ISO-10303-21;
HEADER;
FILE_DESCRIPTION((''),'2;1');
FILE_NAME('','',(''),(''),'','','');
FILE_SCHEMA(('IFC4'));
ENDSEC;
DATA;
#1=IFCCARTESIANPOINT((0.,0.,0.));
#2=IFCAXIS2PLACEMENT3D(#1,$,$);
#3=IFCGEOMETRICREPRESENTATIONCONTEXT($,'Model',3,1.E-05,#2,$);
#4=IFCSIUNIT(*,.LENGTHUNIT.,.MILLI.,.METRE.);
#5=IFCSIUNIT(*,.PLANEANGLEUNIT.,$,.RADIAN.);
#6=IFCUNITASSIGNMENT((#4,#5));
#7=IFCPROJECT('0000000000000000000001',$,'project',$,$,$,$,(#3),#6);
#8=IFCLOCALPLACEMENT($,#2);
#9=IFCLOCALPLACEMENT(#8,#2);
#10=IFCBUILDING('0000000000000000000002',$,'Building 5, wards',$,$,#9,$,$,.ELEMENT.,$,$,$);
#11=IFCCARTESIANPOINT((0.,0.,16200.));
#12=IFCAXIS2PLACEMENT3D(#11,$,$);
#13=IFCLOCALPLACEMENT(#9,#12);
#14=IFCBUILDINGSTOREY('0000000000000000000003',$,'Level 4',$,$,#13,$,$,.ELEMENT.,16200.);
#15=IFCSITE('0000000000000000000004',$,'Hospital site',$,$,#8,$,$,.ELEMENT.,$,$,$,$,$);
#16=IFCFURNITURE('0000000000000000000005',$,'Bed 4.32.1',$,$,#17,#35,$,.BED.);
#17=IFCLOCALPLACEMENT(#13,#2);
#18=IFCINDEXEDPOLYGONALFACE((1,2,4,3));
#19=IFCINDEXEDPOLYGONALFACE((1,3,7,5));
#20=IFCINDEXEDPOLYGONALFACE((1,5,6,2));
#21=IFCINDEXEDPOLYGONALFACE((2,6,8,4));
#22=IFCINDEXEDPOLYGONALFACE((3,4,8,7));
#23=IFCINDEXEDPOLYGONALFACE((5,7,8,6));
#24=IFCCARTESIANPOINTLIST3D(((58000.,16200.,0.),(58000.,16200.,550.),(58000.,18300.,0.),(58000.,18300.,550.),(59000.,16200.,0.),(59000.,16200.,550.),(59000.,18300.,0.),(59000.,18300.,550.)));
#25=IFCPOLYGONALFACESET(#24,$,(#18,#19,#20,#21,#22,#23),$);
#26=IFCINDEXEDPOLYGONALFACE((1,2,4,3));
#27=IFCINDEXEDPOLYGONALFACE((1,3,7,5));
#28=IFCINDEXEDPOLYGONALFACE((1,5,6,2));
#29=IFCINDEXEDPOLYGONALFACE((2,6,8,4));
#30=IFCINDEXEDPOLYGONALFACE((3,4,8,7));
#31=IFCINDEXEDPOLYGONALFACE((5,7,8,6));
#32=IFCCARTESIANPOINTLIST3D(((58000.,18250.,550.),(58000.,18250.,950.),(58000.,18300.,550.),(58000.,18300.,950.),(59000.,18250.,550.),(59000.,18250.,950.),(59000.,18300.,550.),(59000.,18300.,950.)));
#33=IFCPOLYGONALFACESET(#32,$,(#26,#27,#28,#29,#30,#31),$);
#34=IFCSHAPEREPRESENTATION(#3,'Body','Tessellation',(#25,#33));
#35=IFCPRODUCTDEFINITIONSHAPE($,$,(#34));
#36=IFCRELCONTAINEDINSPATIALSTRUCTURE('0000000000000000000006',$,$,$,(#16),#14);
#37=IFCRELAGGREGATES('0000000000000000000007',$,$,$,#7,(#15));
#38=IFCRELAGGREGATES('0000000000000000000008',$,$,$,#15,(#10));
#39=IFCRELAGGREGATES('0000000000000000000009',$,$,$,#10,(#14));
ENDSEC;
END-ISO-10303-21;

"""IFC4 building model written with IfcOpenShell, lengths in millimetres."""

from ifc_helpers import new_model, si_unit, frame, frame_2d, origin, place, context, project, spatial, rectangle, extrude, element, save


model = new_model("IFC4")

# Units and contexts
model_context = context("Model", 3, precision=1e-05, world=origin())
ifc_project = project(units=[si_unit("LENGTHUNIT", "METRE", prefix="MILLI"), si_unit("PLANEANGLEUNIT", "RADIAN")], contexts=[model_context])

# Site, building, storey
site_placement = place(None, origin())
site = spatial("IfcSite", under=ifc_project, at=site_placement, Name="Hospital site", CompositionType="ELEMENT")
building_placement = place(site_placement, origin())
building = spatial("IfcBuilding", under=site, at=building_placement, Name="Building 5, wards", CompositionType="ELEMENT")
storey_placement = place(building_placement, frame((0.0, 0.0, 16200.0)))
storey = spatial("IfcBuildingStorey", under=building, at=storey_placement, Name="Level 4", CompositionType="ELEMENT", Elevation=16200.0)

# Furniture
furniture_placement = place(storey_placement, frame((58000.0, 16200.0, 0.0)))
element("IfcFurniture", 1, at=furniture_placement, inside=storey, Name="Bed 4.32.1", PredefinedType="BED", context=model_context, shape_type="SweptSolid", body=[
    extrude(rectangle(XDim=1000.0, YDim=2100.0, at=frame_2d((500.0, 1050.0))), origin(), (0.0, 0.0, 1.0), 550.0),
    extrude(rectangle(XDim=1000.0, YDim=50.0, at=frame_2d((500.0, 2075.0))), frame((0.0, 0.0, 550.0)), (0.0, 0.0, 1.0), 400.0),
])

save(model, "model.ifc")
